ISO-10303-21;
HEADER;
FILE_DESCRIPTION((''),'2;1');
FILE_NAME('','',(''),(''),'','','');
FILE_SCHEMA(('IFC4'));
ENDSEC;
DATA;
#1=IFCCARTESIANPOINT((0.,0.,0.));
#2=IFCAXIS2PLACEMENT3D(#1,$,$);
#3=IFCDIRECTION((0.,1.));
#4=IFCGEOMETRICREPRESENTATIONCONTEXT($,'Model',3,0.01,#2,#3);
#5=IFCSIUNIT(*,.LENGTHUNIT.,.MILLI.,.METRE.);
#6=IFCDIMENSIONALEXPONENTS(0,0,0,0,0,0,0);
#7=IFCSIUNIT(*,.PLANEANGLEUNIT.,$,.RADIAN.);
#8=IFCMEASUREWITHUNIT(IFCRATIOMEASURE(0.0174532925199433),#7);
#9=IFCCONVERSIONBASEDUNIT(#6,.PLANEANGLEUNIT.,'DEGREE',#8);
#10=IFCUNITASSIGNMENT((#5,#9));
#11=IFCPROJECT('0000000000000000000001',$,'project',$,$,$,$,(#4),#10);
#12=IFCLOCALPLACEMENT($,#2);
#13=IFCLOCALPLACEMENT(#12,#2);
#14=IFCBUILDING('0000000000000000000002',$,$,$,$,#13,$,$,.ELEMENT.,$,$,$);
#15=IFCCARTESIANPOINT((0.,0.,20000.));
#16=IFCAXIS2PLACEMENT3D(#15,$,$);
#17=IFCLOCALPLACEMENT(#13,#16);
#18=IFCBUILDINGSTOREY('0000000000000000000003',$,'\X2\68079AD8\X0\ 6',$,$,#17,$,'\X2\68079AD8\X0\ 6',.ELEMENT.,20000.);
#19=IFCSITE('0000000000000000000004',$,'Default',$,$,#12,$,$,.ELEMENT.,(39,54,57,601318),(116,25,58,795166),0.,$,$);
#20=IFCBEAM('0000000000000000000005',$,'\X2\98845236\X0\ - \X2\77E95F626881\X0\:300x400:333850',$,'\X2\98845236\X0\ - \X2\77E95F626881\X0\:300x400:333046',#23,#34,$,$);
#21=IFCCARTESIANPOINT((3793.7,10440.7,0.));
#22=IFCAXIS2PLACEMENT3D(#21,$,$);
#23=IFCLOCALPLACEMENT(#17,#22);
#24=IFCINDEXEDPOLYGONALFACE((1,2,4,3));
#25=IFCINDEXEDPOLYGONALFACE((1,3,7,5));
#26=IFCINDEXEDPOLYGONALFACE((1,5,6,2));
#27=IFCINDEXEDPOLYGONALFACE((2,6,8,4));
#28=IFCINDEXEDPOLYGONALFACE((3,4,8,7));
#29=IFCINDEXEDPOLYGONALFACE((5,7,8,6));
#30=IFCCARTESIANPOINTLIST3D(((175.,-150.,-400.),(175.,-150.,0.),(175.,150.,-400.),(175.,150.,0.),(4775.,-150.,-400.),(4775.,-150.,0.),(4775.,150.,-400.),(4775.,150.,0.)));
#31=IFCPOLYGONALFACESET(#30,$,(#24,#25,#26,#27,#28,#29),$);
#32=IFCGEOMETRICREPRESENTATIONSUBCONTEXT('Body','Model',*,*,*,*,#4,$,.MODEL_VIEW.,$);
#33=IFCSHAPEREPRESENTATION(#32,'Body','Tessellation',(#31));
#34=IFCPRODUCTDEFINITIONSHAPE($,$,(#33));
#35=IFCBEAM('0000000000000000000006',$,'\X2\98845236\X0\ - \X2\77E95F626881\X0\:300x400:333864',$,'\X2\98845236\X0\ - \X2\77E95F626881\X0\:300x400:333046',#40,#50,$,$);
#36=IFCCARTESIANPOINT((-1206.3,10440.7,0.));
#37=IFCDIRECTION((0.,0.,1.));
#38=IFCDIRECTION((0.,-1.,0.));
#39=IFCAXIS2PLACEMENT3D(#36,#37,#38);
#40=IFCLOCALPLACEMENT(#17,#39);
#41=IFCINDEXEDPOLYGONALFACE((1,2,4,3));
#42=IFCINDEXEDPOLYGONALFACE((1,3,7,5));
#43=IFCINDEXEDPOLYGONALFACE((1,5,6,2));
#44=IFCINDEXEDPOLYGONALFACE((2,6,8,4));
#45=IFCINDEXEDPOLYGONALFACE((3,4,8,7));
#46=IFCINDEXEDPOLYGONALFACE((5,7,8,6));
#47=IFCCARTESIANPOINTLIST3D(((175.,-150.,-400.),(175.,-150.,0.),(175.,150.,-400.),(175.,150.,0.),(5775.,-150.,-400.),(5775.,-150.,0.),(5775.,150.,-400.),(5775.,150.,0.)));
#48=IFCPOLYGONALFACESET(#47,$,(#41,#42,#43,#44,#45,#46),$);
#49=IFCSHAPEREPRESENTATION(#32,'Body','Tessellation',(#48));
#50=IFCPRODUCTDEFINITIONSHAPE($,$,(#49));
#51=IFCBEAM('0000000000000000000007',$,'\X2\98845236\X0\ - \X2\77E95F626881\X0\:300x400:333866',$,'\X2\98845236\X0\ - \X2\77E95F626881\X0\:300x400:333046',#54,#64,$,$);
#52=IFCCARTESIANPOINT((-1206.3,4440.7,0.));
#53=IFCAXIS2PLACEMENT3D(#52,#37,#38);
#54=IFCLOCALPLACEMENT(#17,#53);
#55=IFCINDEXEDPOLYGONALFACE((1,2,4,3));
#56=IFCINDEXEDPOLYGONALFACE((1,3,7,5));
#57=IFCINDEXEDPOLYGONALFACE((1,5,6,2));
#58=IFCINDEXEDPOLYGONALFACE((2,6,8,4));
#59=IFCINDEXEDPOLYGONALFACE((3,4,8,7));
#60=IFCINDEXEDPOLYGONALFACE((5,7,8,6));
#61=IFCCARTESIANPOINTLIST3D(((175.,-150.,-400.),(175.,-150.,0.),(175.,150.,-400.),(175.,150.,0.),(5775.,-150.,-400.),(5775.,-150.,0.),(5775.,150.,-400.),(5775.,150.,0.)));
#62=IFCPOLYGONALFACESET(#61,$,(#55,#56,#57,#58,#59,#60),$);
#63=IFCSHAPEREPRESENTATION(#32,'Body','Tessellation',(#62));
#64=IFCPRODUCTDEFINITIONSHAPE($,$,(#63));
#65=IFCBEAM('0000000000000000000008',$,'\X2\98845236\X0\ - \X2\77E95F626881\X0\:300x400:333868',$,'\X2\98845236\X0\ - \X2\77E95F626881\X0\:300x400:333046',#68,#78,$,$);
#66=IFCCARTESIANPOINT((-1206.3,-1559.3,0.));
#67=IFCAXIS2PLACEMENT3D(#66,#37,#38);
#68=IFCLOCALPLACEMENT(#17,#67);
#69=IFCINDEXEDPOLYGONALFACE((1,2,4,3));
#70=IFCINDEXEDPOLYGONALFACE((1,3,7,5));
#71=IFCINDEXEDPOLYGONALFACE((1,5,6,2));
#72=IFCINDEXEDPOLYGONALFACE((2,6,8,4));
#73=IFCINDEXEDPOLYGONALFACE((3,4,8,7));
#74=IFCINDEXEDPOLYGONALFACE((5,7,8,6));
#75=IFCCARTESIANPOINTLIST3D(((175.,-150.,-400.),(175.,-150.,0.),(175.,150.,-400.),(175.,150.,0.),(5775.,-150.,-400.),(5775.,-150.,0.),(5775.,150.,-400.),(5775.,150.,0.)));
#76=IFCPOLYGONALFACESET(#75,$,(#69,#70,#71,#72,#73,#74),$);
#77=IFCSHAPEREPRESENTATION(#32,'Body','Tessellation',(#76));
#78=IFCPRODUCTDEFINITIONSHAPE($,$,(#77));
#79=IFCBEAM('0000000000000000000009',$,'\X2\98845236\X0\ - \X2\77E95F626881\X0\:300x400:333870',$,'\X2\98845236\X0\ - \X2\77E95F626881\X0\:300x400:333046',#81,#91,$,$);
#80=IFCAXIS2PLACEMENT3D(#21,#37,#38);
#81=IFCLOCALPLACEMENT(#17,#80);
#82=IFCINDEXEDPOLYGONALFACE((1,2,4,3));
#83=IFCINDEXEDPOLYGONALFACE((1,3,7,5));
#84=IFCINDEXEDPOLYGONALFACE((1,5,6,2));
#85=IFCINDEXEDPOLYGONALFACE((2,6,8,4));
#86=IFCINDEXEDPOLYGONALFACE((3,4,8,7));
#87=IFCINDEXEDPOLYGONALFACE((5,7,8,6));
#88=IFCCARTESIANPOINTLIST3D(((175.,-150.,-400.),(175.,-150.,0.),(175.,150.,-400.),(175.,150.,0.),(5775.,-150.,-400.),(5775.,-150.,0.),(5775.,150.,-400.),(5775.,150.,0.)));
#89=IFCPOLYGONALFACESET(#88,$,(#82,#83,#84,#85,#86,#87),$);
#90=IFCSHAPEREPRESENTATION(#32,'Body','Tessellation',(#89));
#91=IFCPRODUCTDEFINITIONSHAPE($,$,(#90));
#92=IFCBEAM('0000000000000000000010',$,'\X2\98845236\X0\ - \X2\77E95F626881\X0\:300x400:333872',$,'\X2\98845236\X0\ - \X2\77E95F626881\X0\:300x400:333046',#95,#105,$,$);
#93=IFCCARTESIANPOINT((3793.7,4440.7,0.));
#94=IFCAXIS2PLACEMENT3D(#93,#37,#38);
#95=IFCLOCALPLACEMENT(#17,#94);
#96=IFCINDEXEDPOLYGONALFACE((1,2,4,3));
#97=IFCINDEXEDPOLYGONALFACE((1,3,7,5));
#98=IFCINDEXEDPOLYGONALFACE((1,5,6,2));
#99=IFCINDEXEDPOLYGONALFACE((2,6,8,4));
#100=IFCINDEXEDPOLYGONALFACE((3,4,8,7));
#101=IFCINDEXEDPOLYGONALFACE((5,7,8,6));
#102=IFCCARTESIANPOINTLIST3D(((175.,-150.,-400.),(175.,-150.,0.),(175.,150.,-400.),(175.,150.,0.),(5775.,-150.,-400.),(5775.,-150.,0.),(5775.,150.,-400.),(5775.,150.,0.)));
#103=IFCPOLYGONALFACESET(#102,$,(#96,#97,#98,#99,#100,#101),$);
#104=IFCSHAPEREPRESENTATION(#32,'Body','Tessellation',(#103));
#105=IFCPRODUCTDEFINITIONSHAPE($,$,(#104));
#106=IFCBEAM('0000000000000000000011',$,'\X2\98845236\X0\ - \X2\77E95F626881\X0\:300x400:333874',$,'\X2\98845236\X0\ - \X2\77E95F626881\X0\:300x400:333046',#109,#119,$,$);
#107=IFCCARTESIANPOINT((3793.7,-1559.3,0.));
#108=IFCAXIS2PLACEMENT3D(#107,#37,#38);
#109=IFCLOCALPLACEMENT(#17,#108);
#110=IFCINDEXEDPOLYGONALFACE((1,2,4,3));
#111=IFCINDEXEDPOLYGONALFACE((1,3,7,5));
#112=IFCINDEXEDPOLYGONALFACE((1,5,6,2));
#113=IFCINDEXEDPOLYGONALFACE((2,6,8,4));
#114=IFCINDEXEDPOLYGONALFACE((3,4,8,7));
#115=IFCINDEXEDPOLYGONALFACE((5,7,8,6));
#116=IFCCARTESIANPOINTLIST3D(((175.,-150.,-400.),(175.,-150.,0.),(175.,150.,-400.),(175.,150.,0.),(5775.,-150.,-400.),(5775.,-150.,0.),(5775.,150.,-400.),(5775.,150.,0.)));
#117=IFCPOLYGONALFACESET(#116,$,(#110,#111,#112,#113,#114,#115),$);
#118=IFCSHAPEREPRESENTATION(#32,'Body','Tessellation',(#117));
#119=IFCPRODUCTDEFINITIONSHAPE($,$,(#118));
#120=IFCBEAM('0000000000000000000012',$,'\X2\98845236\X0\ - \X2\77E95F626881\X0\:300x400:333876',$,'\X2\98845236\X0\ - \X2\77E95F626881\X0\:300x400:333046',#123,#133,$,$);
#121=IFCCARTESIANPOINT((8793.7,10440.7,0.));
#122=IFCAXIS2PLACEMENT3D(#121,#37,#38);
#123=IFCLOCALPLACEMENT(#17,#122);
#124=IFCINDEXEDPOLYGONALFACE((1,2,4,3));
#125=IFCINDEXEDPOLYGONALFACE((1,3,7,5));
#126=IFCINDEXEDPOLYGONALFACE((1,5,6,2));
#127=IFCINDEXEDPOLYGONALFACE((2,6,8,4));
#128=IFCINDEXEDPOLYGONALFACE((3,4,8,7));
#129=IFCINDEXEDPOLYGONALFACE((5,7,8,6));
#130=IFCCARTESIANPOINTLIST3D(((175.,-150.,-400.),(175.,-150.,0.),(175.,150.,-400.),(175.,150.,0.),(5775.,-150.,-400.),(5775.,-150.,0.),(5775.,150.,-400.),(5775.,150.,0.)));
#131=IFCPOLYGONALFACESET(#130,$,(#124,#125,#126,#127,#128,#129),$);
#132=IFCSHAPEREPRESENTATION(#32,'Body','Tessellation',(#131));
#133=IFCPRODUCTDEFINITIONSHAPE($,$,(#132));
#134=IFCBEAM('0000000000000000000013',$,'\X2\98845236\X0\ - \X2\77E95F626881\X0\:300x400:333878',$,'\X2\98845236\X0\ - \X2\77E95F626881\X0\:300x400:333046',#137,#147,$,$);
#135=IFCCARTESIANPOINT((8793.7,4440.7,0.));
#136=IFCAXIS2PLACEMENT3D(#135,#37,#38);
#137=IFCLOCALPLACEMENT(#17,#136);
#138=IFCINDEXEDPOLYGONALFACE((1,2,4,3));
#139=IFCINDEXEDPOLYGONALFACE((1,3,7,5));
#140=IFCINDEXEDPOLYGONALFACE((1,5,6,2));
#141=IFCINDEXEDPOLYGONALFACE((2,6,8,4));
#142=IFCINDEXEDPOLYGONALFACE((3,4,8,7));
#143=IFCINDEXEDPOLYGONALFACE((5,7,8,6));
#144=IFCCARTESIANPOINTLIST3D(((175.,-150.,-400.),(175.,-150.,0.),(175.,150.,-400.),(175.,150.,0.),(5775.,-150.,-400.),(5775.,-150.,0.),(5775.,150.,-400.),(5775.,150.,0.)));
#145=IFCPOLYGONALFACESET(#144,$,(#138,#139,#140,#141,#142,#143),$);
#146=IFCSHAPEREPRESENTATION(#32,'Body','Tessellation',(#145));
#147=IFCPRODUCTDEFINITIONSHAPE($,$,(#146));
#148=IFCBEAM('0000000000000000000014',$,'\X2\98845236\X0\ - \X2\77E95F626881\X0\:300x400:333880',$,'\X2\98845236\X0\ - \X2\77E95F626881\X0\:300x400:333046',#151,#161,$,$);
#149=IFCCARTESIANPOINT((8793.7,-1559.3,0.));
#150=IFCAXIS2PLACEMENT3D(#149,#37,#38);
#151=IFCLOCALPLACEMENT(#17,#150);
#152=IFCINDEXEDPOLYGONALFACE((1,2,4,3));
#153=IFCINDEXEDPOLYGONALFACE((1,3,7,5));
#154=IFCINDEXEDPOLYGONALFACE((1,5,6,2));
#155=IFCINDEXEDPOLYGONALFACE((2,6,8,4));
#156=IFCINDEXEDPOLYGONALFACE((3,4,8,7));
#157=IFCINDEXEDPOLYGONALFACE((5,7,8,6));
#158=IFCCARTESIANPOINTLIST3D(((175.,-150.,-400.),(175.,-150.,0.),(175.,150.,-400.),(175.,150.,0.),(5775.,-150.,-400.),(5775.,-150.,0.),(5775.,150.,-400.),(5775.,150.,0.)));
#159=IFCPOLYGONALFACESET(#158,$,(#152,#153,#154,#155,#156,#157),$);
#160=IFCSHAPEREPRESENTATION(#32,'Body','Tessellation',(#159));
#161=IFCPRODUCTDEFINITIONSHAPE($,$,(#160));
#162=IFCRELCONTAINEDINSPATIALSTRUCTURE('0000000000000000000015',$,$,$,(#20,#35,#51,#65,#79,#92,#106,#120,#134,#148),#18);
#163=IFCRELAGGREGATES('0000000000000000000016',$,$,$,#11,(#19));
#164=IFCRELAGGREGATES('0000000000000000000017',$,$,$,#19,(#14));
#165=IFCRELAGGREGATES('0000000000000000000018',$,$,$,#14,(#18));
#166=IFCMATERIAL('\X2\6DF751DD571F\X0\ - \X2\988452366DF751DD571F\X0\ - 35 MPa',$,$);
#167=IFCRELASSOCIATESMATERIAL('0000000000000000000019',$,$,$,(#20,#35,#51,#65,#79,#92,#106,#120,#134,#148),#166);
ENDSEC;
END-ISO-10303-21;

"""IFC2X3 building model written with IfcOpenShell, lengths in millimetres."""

from ifc_helpers import new_model, entity, si_unit, converted_unit, direction, frame, frame_2d, origin, origin_2d_with_axis, place, context, subcontext, project, spatial, rectangle, extrude, material, element, save


model = new_model("IFC2X3")

# Units and contexts
model_context = context("Model", 3, precision=0.01, world=origin(), true_north=direction((0.0, 1.0)))
body_context = subcontext(model_context, "Body", "Model", "MODEL_VIEW")
ifc_project = project(units=[si_unit("LENGTHUNIT", "METRE", prefix="MILLI"), converted_unit("PLANEANGLEUNIT", "DEGREE", entity("IfcRatioMeasure", 0.0174532925199433), si_unit("PLANEANGLEUNIT", "RADIAN"), dimensions=[0, 0, 0, 0, 0, 0, 0])], contexts=[model_context])

# Site, building, storey
site_placement = place(None, origin())
site = spatial("IfcSite", under=ifc_project, at=site_placement, Name="Default", CompositionType="ELEMENT", RefLatitude=(39, 54, 57, 601318), RefLongitude=(116, 25, 58, 795166), RefElevation=0.0)
building_placement = place(site_placement, origin())
building = spatial("IfcBuilding", under=site, at=building_placement, CompositionType="ELEMENT")
storey_placement = place(building_placement, frame((0.0, 0.0, 20000.0)))
storey = spatial("IfcBuildingStorey", under=building, at=storey_placement, Name="标高 6", LongName="标高 6", CompositionType="ELEMENT", Elevation=20000.0)

# Shared definitions
ifc_material_1 = material(Name="混凝土 - 预制混凝土 - 35 MPa")

# Beams
beam_1_placement = place(storey_placement, frame((3793.7, 10440.7, 0.0)))
element("IfcBeam", 1, at=beam_1_placement, inside=storey, material=ifc_material_1, Name="预制 - 矩形梁:300x400:333850", ObjectType="预制 - 矩形梁:300x400:333046", context=body_context, shape_type="SweptSolid", body=[
    extrude(rectangle(XDim=400.0, YDim=300.0, at=frame_2d((0.0, 0.0), x_axis=(1.0, 0.0))), frame((175.0, 0.0, -200.0), z_axis=(1.0, 0.0, 0.0), x_axis=(0.0, 0.0, -1.0)), (0.0, 0.0, 1.0), 4600.0),
])
beam_2_placement = place(storey_placement, frame((-1206.3, 10440.7, 0.0), z_axis=(0.0, 0.0, 1.0), x_axis=(0.0, -1.0, 0.0)))
element("IfcBeam", 2, at=beam_2_placement, inside=storey, material=ifc_material_1, Name="预制 - 矩形梁:300x400:333864", ObjectType="预制 - 矩形梁:300x400:333046", context=body_context, shape_type="SweptSolid", body=[
    extrude(rectangle(XDim=400.0, YDim=300.0, at=frame_2d((0.0, 0.0), x_axis=(1.0, 0.0))), frame((175.0, 0.0, -200.0), z_axis=(1.0, 0.0, 0.0), x_axis=(0.0, 0.0, -1.0)), (0.0, 0.0, 1.0), 5600.0),
])
beam_3_placement = place(storey_placement, frame((-1206.3, 4440.7, 0.0), z_axis=(0.0, 0.0, 1.0), x_axis=(0.0, -1.0, 0.0)))
element("IfcBeam", 3, at=beam_3_placement, inside=storey, material=ifc_material_1, Name="预制 - 矩形梁:300x400:333866", ObjectType="预制 - 矩形梁:300x400:333046", context=body_context, shape_type="SweptSolid", body=[
    extrude(rectangle(XDim=400.0, YDim=300.0, at=frame_2d((0.0, 0.0), x_axis=(1.0, 0.0))), frame((175.0, 0.0, -200.0), z_axis=(1.0, 0.0, 0.0), x_axis=(0.0, 0.0, -1.0)), (0.0, 0.0, 1.0), 5600.0),
])
beam_4_placement = place(storey_placement, frame((-1206.3, -1559.3, 0.0), z_axis=(0.0, 0.0, 1.0), x_axis=(0.0, -1.0, 0.0)))
element("IfcBeam", 4, at=beam_4_placement, inside=storey, material=ifc_material_1, Name="预制 - 矩形梁:300x400:333868", ObjectType="预制 - 矩形梁:300x400:333046", context=body_context, shape_type="SweptSolid", body=[
    extrude(rectangle(XDim=400.0, YDim=300.0, at=frame_2d((0.0, 0.0), x_axis=(1.0, 0.0))), frame((175.0, 0.0, -200.0), z_axis=(1.0, 0.0, 0.0), x_axis=(0.0, 0.0, -1.0)), (0.0, 0.0, 1.0), 5600.0),
])
beam_5_placement = place(storey_placement, frame((3793.7, 10440.7, 0.0), z_axis=(0.0, 0.0, 1.0), x_axis=(0.0, -1.0, 0.0)))
element("IfcBeam", 5, at=beam_5_placement, inside=storey, material=ifc_material_1, Name="预制 - 矩形梁:300x400:333870", ObjectType="预制 - 矩形梁:300x400:333046", context=body_context, shape_type="SweptSolid", body=[
    extrude(rectangle(XDim=400.0, YDim=300.0, at=frame_2d((0.0, 0.0), x_axis=(1.0, 0.0))), frame((175.0, 0.0, -200.0), z_axis=(1.0, 0.0, 0.0), x_axis=(0.0, 0.0, -1.0)), (0.0, 0.0, 1.0), 5600.0),
])
beam_6_placement = place(storey_placement, frame((3793.7, 4440.7, 0.0), z_axis=(0.0, 0.0, 1.0), x_axis=(0.0, -1.0, 0.0)))
element("IfcBeam", 6, at=beam_6_placement, inside=storey, material=ifc_material_1, Name="预制 - 矩形梁:300x400:333872", ObjectType="预制 - 矩形梁:300x400:333046", context=body_context, shape_type="SweptSolid", body=[
    extrude(rectangle(XDim=400.0, YDim=300.0, at=origin_2d_with_axis()), frame((175.0, 0.0, -200.0), z_axis=(1.0, 0.0, 0.0), x_axis=(0.0, 0.0, -1.0)), (0.0, 0.0, 1.0), 5600.0),
])
beam_7_placement = place(storey_placement, frame((3793.7, -1559.3, 0.0), z_axis=(0.0, 0.0, 1.0), x_axis=(0.0, -1.0, 0.0)))
element("IfcBeam", 7, at=beam_7_placement, inside=storey, material=ifc_material_1, Name="预制 - 矩形梁:300x400:333874", ObjectType="预制 - 矩形梁:300x400:333046", context=body_context, shape_type="SweptSolid", body=[
    extrude(rectangle(XDim=400.0, YDim=300.0, at=frame_2d((0.0, 0.0), x_axis=(1.0, 0.0))), frame((175.0, 0.0, -200.0), z_axis=(1.0, 0.0, 0.0), x_axis=(0.0, 0.0, -1.0)), (0.0, 0.0, 1.0), 5600.0),
])
for number, where, z_axis, x_axis, name in (
    (8, (8793.7, 10440.7, 0.0), (0.0, 0.0, 1.0), (0.0, -1.0, 0.0), "预制 - 矩形梁:300x400:333876"),
    (9, (8793.7, 4440.7, 0.0), (0.0, 0.0, 1.0), (0.0, -1.0, 0.0), "预制 - 矩形梁:300x400:333878"),
    (10, (8793.7, -1559.3, 0.0), (0.0, 0.0, 1.0), (0.0, -1.0, 0.0), "预制 - 矩形梁:300x400:333880"),
):
    element("IfcBeam", number, at=place(storey_placement, frame(where, z_axis=z_axis, x_axis=x_axis)), inside=storey, material=ifc_material_1, Name=name, ObjectType="预制 - 矩形梁:300x400:333046", context=body_context, shape_type="SweptSolid", body=[
        extrude(rectangle(XDim=400.0, YDim=300.0, at=origin_2d_with_axis()), frame((175.0, 0.0, -200.0), z_axis=(1.0, 0.0, 0.0), x_axis=(0.0, 0.0, -1.0)), (0.0, 0.0, 1.0), 5600.0),
    ])

save(model, "model.ifc")
